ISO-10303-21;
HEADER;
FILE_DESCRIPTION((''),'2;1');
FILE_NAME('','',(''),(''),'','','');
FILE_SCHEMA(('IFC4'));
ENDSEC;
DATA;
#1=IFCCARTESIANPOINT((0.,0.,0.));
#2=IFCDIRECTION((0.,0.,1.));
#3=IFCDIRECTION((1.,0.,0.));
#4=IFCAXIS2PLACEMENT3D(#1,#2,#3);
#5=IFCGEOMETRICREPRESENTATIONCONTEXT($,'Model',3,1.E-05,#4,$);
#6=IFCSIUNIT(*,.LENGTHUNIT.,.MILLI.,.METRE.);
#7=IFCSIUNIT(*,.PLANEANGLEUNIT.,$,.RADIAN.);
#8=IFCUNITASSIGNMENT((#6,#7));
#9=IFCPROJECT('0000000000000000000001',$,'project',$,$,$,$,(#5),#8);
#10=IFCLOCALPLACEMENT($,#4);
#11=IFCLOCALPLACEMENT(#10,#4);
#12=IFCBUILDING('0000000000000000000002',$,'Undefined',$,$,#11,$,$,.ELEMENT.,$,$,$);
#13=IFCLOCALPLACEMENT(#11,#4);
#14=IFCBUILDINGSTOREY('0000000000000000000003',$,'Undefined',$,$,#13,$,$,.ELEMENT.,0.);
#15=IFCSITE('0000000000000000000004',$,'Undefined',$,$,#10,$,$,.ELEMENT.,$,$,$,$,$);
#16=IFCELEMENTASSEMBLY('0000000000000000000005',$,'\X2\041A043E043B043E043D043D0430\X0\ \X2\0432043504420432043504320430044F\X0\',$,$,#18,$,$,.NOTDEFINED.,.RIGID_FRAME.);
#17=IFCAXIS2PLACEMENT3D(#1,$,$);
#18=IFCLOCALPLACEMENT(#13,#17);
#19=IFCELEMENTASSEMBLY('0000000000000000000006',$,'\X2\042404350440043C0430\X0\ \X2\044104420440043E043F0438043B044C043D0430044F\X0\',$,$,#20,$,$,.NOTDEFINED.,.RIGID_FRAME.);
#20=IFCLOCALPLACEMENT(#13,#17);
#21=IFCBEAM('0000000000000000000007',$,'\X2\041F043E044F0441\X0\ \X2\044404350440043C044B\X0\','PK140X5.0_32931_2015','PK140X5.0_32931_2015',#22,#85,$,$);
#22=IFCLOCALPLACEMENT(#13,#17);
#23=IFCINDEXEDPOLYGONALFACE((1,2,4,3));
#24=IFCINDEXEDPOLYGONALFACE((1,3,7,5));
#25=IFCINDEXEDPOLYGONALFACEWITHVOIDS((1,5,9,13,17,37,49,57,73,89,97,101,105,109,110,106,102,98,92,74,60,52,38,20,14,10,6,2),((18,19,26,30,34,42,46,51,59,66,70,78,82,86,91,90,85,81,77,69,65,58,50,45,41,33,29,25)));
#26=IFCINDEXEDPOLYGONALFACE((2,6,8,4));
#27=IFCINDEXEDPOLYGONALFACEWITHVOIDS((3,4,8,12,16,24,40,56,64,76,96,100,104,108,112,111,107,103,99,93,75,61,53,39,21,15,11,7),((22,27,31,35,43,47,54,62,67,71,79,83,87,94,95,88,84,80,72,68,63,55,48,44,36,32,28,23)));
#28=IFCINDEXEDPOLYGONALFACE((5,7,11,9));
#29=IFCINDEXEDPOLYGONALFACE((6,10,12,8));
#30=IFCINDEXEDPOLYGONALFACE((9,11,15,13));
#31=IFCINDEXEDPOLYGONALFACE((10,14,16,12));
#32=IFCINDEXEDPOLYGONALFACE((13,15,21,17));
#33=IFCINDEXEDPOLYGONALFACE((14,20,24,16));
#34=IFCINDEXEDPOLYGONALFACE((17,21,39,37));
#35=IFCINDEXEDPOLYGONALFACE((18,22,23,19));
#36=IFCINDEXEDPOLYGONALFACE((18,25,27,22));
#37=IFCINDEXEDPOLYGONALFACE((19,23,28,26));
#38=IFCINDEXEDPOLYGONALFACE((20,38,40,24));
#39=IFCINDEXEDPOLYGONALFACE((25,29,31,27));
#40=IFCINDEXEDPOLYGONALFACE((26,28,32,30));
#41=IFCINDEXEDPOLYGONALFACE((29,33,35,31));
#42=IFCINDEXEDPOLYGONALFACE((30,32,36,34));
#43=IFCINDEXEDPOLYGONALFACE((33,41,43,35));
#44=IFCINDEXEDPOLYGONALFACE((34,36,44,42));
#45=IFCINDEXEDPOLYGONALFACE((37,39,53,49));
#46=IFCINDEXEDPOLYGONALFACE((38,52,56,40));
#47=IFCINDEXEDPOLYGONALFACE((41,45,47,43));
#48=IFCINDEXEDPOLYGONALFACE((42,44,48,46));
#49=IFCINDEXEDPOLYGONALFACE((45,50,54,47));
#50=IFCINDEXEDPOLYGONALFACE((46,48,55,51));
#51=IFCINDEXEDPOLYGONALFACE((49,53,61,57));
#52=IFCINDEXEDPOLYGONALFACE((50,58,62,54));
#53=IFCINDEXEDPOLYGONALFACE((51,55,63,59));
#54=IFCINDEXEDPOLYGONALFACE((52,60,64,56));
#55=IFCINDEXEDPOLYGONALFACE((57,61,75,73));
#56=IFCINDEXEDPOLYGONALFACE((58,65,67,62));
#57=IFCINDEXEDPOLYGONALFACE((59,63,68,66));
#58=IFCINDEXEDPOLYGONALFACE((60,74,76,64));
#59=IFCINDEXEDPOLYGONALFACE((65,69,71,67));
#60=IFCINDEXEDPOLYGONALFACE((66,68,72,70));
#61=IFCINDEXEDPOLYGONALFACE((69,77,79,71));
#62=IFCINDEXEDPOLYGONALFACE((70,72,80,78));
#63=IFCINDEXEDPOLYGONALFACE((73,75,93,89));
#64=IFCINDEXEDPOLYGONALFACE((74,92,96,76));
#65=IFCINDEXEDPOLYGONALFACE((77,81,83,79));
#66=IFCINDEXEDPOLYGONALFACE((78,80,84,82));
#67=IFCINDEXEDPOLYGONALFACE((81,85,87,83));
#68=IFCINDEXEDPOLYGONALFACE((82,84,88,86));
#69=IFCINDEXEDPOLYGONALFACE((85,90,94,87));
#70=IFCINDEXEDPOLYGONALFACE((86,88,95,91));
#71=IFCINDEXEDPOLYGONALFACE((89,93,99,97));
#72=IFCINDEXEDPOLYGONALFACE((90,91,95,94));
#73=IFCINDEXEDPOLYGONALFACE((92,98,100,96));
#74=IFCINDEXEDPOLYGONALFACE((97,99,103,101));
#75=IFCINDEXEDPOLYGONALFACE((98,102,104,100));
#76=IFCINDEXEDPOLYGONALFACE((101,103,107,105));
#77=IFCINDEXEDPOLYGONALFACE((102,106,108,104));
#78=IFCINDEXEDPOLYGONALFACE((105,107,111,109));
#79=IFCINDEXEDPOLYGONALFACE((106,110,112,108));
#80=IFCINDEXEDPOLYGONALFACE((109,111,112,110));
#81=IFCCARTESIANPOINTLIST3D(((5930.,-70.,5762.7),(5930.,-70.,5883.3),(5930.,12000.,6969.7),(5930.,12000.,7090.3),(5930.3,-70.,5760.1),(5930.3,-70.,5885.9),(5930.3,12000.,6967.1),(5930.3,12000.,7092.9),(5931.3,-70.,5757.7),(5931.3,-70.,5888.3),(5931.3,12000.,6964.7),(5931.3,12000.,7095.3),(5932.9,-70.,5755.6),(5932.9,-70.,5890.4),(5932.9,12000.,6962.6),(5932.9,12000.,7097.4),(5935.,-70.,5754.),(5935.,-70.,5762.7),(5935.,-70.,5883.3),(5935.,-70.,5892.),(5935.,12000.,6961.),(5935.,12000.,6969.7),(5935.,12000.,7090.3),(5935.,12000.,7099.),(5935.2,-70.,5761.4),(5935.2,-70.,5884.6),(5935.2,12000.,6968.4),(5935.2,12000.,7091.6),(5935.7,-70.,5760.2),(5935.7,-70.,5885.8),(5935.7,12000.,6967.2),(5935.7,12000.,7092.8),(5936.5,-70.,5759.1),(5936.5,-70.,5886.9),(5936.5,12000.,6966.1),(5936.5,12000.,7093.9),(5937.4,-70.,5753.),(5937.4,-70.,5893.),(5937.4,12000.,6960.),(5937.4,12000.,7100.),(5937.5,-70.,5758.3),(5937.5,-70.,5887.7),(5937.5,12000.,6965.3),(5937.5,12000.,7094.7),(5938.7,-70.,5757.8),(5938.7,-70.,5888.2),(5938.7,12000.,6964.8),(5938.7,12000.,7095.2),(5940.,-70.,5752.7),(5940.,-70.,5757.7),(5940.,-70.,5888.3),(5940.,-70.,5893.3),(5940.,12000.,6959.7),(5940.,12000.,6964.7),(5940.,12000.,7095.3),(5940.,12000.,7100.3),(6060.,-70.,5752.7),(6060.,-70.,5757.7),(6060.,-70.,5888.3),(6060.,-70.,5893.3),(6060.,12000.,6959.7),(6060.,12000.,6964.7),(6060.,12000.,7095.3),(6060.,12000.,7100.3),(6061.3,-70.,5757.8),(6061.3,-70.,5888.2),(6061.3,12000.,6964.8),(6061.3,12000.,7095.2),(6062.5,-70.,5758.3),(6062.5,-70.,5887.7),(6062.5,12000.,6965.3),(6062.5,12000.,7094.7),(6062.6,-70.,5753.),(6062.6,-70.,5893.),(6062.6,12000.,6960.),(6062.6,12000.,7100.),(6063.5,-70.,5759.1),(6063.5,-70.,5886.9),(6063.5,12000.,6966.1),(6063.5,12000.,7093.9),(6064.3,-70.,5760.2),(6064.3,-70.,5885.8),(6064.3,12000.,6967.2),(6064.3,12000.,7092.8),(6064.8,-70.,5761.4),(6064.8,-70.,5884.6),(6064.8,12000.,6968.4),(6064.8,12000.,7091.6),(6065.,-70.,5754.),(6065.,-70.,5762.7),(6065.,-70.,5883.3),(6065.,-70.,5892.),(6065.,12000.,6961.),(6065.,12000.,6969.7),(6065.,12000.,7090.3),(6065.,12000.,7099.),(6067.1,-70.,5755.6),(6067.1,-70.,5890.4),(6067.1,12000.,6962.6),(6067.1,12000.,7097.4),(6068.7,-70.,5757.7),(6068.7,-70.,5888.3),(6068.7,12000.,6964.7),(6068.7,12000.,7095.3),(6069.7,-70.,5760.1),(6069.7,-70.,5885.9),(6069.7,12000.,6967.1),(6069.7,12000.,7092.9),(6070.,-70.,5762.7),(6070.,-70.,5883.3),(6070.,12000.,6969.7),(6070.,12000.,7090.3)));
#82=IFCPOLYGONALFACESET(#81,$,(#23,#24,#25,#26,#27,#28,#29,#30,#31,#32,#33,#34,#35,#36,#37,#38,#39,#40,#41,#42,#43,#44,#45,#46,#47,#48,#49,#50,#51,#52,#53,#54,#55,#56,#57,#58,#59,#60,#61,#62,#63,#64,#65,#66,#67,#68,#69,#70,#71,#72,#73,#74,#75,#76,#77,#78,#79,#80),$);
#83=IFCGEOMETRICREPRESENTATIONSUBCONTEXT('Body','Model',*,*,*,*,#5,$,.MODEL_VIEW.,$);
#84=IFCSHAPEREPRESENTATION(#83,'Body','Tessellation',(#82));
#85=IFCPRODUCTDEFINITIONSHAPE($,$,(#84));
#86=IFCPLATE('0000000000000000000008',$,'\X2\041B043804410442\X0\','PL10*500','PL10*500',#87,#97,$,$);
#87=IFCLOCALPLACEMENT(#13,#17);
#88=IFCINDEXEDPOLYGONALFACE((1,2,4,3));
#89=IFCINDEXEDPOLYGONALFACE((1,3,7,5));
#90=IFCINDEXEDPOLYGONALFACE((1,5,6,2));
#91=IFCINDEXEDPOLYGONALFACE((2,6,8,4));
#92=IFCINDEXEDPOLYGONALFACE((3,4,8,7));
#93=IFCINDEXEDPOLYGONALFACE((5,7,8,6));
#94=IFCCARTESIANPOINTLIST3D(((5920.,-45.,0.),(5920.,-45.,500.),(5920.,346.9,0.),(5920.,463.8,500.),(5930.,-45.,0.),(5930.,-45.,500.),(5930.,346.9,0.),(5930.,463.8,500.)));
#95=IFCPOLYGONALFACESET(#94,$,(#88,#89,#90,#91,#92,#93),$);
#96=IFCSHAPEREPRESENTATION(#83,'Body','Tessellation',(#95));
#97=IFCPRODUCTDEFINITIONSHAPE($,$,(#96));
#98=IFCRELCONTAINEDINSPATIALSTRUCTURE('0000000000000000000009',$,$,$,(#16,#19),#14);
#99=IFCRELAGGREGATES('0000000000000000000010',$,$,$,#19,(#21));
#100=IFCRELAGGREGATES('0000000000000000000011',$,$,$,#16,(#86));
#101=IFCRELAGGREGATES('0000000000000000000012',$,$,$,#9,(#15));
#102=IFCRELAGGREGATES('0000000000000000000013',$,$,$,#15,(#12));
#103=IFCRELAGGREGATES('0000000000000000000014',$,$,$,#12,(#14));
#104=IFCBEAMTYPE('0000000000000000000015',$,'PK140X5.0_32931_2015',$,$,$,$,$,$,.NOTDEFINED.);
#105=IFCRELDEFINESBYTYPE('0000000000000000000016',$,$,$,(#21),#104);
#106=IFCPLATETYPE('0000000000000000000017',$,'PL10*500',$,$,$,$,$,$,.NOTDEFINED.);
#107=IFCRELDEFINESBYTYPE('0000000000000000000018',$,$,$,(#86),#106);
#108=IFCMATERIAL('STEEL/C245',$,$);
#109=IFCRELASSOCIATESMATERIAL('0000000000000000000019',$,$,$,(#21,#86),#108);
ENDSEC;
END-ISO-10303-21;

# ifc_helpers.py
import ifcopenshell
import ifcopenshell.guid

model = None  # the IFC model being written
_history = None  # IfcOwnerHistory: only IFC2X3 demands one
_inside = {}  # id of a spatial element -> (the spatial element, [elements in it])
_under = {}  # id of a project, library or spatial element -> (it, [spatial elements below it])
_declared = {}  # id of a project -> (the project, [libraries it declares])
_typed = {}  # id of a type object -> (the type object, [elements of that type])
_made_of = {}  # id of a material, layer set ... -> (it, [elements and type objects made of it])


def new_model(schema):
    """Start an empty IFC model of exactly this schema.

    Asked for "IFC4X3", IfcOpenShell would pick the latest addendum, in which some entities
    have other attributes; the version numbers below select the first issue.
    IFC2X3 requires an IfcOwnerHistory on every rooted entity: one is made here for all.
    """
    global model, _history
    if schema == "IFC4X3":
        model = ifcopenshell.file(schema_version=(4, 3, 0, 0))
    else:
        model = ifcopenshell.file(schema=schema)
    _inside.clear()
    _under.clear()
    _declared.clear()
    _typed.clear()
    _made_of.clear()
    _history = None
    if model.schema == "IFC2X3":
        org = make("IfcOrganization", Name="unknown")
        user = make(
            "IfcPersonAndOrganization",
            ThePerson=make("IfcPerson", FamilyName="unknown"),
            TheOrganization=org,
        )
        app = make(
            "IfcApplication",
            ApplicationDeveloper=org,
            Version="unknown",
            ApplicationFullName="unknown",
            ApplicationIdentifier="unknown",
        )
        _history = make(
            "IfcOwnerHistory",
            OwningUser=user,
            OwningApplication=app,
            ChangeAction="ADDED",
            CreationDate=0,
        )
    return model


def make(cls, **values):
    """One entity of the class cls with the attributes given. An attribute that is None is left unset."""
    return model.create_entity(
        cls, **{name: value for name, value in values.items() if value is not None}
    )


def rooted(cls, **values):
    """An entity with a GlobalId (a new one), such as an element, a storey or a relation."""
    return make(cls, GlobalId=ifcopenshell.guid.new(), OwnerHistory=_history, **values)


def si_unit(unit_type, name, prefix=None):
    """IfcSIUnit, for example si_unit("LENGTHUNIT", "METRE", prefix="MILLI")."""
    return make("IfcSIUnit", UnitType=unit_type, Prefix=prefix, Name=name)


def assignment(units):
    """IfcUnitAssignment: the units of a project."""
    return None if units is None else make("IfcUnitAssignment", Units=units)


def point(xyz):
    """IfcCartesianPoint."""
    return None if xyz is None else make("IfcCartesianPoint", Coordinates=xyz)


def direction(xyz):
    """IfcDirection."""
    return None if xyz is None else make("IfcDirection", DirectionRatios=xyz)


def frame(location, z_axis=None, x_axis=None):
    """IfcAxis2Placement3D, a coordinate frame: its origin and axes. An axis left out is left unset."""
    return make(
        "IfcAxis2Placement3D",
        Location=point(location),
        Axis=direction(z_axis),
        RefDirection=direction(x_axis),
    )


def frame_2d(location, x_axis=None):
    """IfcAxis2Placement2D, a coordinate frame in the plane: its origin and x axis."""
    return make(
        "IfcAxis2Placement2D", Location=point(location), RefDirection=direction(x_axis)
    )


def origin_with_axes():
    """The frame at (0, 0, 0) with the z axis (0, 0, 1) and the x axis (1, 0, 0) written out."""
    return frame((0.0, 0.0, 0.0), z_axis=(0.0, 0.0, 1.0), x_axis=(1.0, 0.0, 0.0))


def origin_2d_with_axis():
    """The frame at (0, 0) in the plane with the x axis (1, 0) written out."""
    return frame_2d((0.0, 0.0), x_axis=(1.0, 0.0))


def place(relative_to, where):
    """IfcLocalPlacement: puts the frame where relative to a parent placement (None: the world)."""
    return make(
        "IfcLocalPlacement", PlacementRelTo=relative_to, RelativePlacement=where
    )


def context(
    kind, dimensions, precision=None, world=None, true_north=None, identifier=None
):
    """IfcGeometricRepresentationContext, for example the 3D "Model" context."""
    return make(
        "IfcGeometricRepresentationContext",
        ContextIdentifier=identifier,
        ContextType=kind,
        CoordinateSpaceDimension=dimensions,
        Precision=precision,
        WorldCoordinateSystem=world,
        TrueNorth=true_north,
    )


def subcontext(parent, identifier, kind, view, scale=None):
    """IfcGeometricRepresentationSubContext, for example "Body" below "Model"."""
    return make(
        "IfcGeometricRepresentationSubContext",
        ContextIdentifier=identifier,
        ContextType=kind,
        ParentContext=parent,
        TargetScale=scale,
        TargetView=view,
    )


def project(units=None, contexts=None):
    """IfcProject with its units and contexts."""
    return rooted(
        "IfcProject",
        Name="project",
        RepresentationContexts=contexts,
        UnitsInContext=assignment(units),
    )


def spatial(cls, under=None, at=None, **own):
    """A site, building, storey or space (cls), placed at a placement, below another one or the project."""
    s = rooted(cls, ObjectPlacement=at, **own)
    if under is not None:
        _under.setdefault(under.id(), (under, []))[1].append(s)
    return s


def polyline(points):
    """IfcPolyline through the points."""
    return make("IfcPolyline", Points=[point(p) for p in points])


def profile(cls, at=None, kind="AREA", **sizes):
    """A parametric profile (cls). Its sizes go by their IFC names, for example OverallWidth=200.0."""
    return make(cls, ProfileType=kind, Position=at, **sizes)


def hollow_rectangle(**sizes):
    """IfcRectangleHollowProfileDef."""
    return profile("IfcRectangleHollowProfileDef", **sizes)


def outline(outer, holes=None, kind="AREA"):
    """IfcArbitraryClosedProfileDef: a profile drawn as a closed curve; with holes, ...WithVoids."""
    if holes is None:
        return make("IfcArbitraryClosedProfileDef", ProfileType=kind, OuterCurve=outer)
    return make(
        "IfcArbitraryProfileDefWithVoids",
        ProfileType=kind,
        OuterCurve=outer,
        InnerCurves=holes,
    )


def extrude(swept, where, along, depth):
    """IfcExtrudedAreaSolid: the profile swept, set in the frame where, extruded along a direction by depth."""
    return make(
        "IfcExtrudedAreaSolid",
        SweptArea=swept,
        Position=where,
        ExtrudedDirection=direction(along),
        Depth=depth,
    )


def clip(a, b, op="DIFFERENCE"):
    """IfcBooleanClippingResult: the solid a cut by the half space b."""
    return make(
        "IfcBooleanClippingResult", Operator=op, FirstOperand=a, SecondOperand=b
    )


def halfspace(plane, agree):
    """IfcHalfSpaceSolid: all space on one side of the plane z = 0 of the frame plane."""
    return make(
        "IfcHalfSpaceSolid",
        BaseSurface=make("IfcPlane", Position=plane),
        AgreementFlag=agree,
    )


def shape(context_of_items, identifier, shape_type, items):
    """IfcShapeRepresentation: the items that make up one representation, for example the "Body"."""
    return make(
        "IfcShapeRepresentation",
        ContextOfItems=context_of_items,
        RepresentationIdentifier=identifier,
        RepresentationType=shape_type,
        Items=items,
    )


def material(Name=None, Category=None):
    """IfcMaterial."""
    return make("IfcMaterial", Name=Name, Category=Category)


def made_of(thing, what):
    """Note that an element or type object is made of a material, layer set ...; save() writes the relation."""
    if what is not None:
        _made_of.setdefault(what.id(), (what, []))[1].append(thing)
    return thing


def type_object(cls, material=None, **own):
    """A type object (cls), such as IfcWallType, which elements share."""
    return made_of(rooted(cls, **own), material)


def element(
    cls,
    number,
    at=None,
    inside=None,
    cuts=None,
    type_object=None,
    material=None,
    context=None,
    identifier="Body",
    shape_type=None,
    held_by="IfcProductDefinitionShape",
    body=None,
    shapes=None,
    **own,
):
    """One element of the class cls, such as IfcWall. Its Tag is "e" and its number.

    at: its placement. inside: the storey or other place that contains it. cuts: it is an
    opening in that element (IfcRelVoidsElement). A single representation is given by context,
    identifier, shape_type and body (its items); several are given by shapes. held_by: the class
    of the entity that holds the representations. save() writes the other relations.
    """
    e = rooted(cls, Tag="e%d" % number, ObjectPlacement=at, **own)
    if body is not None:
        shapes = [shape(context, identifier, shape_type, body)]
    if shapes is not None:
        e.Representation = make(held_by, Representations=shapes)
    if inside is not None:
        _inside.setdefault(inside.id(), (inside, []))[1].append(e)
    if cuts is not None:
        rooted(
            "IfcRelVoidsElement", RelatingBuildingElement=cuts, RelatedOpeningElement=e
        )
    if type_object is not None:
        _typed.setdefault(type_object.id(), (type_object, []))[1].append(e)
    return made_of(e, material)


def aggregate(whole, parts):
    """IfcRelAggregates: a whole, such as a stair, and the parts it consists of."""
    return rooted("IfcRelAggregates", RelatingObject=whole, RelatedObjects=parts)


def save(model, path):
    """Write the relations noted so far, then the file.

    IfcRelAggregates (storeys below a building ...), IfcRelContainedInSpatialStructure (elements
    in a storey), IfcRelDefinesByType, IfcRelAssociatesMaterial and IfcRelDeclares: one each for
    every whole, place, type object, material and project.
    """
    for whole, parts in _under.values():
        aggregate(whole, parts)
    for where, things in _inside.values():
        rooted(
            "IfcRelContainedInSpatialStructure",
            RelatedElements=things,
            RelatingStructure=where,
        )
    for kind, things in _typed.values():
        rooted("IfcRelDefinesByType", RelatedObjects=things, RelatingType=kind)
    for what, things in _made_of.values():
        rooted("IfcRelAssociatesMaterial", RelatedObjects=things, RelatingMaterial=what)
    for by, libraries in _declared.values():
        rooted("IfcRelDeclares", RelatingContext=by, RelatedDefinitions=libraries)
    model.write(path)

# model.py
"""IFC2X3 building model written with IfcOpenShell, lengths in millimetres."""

from ifc_helpers import new_model, si_unit, frame, origin_with_axes, origin_2d_with_axis, place, context, subcontext, project, spatial, polyline, hollow_rectangle, outline, extrude, clip, halfspace, material, type_object, element, aggregate, save


model = new_model("IFC2X3")

# Units and contexts
model_context = context("Model", 3, precision=1e-05, world=origin_with_axes())
body_context = subcontext(model_context, "Body", "Model", "MODEL_VIEW")
ifc_project = project(units=[si_unit("LENGTHUNIT", "METRE", prefix="MILLI"), si_unit("PLANEANGLEUNIT", "RADIAN")], contexts=[model_context])

# Site, building, storey
site_placement = place(None, origin_with_axes())
site = spatial("IfcSite", under=ifc_project, at=site_placement, Name="Undefined", CompositionType="ELEMENT")
building_placement = place(site_placement, origin_with_axes())
building = spatial("IfcBuilding", under=site, at=building_placement, Name="Undefined", CompositionType="ELEMENT")
storey_placement = place(building_placement, origin_with_axes())
storey = spatial("IfcBuildingStorey", under=building, at=storey_placement, Name="Undefined", CompositionType="ELEMENT", Elevation=0.0)

# Shared definitions
ifc_material_1 = material(Name="STEEL/C245")

# Element assembly
assembly_1_placement = place(storey_placement, origin_with_axes())
assembly_1 = element("IfcElementAssembly", 1, at=assembly_1_placement, inside=storey, Name="Колонна ветвевая", AssemblyPlace="NOTDEFINED", PredefinedType="RIGID_FRAME")

# Element assembly
assembly_2_placement = place(storey_placement, origin_with_axes())
assembly_2 = element("IfcElementAssembly", 2, at=assembly_2_placement, inside=storey, Name="Ферма стропильная", AssemblyPlace="NOTDEFINED", PredefinedType="RIGID_FRAME")

# Beam
beam_type_1 = type_object("IfcBeamType", Name="PK140X5.0_32931_2015", PredefinedType="NOTDEFINED")
beam_1_placement = place(assembly_2_placement, frame((6000.0, 0.0, 5830.0), z_axis=(0.0, -0.099504, 0.995037), x_axis=(0.0, 0.995037, 0.099504)))
beam_1 = element("IfcBeam", 3, at=beam_1_placement, type_object=beam_type_1, material=ifc_material_1, Name="Пояс фермы", Description="PK140X5.0_32931_2015", ObjectType="PK140X5.0_32931_2015", context=body_context, shape_type="Clipping", body=[
    clip(clip(extrude(hollow_rectangle(XDim=140.0, YDim=140.0, WallThickness=5.0, InnerFilletRadius=5.0, OuterFilletRadius=10.0, at=origin_2d_with_axis()), frame((12074.0, 0.0, 0.0), z_axis=(-1.0, 0.0, 0.0), x_axis=(0.0, -1.0, 0.0)), (0.0, 0.0, 1.0), 12158.5), halfspace(frame((12239.3, 0.0, 1794.2), z_axis=(0.995037, 0.0, -0.099504), x_axis=(0.0, -1.0, 0.0)), False)), halfspace(frame((-65.6, 0.0, 47.4), z_axis=(0.995037, 0.0, -0.099504), x_axis=(0.0, -1.0, 0.0)), True)),
])
aggregate(assembly_2, [beam_1])

# Plate
plate_type = type_object("IfcPlateType", Name="PL10*500", PredefinedType="NOTDEFINED")
plate_placement = place(assembly_1_placement, frame((5925.0, -45.0, 500.0), z_axis=(1.0, 0.0, 0.0), x_axis=(0.0, 0.0, -1.0)))
plate = element("IfcPlate", 4, at=plate_placement, type_object=plate_type, material=ifc_material_1, Name="Лист", Description="PL10*500", ObjectType="PL10*500", context=body_context, shape_type="SweptSolid", body=[
    extrude(outline(polyline([(0.0, 0.0), (500.0, 0.0), (500.0, 391.9), (0.0, 508.8), (0.0, 0.0)])), frame((0.0, 0.0, -5.0), z_axis=(0.0, 0.0, 1.0), x_axis=(1.0, 0.0, 0.0)), (0.0, 0.0, 1.0), 10.0),
])
aggregate(assembly_1, [plate])

save(model, "model.ifc")
